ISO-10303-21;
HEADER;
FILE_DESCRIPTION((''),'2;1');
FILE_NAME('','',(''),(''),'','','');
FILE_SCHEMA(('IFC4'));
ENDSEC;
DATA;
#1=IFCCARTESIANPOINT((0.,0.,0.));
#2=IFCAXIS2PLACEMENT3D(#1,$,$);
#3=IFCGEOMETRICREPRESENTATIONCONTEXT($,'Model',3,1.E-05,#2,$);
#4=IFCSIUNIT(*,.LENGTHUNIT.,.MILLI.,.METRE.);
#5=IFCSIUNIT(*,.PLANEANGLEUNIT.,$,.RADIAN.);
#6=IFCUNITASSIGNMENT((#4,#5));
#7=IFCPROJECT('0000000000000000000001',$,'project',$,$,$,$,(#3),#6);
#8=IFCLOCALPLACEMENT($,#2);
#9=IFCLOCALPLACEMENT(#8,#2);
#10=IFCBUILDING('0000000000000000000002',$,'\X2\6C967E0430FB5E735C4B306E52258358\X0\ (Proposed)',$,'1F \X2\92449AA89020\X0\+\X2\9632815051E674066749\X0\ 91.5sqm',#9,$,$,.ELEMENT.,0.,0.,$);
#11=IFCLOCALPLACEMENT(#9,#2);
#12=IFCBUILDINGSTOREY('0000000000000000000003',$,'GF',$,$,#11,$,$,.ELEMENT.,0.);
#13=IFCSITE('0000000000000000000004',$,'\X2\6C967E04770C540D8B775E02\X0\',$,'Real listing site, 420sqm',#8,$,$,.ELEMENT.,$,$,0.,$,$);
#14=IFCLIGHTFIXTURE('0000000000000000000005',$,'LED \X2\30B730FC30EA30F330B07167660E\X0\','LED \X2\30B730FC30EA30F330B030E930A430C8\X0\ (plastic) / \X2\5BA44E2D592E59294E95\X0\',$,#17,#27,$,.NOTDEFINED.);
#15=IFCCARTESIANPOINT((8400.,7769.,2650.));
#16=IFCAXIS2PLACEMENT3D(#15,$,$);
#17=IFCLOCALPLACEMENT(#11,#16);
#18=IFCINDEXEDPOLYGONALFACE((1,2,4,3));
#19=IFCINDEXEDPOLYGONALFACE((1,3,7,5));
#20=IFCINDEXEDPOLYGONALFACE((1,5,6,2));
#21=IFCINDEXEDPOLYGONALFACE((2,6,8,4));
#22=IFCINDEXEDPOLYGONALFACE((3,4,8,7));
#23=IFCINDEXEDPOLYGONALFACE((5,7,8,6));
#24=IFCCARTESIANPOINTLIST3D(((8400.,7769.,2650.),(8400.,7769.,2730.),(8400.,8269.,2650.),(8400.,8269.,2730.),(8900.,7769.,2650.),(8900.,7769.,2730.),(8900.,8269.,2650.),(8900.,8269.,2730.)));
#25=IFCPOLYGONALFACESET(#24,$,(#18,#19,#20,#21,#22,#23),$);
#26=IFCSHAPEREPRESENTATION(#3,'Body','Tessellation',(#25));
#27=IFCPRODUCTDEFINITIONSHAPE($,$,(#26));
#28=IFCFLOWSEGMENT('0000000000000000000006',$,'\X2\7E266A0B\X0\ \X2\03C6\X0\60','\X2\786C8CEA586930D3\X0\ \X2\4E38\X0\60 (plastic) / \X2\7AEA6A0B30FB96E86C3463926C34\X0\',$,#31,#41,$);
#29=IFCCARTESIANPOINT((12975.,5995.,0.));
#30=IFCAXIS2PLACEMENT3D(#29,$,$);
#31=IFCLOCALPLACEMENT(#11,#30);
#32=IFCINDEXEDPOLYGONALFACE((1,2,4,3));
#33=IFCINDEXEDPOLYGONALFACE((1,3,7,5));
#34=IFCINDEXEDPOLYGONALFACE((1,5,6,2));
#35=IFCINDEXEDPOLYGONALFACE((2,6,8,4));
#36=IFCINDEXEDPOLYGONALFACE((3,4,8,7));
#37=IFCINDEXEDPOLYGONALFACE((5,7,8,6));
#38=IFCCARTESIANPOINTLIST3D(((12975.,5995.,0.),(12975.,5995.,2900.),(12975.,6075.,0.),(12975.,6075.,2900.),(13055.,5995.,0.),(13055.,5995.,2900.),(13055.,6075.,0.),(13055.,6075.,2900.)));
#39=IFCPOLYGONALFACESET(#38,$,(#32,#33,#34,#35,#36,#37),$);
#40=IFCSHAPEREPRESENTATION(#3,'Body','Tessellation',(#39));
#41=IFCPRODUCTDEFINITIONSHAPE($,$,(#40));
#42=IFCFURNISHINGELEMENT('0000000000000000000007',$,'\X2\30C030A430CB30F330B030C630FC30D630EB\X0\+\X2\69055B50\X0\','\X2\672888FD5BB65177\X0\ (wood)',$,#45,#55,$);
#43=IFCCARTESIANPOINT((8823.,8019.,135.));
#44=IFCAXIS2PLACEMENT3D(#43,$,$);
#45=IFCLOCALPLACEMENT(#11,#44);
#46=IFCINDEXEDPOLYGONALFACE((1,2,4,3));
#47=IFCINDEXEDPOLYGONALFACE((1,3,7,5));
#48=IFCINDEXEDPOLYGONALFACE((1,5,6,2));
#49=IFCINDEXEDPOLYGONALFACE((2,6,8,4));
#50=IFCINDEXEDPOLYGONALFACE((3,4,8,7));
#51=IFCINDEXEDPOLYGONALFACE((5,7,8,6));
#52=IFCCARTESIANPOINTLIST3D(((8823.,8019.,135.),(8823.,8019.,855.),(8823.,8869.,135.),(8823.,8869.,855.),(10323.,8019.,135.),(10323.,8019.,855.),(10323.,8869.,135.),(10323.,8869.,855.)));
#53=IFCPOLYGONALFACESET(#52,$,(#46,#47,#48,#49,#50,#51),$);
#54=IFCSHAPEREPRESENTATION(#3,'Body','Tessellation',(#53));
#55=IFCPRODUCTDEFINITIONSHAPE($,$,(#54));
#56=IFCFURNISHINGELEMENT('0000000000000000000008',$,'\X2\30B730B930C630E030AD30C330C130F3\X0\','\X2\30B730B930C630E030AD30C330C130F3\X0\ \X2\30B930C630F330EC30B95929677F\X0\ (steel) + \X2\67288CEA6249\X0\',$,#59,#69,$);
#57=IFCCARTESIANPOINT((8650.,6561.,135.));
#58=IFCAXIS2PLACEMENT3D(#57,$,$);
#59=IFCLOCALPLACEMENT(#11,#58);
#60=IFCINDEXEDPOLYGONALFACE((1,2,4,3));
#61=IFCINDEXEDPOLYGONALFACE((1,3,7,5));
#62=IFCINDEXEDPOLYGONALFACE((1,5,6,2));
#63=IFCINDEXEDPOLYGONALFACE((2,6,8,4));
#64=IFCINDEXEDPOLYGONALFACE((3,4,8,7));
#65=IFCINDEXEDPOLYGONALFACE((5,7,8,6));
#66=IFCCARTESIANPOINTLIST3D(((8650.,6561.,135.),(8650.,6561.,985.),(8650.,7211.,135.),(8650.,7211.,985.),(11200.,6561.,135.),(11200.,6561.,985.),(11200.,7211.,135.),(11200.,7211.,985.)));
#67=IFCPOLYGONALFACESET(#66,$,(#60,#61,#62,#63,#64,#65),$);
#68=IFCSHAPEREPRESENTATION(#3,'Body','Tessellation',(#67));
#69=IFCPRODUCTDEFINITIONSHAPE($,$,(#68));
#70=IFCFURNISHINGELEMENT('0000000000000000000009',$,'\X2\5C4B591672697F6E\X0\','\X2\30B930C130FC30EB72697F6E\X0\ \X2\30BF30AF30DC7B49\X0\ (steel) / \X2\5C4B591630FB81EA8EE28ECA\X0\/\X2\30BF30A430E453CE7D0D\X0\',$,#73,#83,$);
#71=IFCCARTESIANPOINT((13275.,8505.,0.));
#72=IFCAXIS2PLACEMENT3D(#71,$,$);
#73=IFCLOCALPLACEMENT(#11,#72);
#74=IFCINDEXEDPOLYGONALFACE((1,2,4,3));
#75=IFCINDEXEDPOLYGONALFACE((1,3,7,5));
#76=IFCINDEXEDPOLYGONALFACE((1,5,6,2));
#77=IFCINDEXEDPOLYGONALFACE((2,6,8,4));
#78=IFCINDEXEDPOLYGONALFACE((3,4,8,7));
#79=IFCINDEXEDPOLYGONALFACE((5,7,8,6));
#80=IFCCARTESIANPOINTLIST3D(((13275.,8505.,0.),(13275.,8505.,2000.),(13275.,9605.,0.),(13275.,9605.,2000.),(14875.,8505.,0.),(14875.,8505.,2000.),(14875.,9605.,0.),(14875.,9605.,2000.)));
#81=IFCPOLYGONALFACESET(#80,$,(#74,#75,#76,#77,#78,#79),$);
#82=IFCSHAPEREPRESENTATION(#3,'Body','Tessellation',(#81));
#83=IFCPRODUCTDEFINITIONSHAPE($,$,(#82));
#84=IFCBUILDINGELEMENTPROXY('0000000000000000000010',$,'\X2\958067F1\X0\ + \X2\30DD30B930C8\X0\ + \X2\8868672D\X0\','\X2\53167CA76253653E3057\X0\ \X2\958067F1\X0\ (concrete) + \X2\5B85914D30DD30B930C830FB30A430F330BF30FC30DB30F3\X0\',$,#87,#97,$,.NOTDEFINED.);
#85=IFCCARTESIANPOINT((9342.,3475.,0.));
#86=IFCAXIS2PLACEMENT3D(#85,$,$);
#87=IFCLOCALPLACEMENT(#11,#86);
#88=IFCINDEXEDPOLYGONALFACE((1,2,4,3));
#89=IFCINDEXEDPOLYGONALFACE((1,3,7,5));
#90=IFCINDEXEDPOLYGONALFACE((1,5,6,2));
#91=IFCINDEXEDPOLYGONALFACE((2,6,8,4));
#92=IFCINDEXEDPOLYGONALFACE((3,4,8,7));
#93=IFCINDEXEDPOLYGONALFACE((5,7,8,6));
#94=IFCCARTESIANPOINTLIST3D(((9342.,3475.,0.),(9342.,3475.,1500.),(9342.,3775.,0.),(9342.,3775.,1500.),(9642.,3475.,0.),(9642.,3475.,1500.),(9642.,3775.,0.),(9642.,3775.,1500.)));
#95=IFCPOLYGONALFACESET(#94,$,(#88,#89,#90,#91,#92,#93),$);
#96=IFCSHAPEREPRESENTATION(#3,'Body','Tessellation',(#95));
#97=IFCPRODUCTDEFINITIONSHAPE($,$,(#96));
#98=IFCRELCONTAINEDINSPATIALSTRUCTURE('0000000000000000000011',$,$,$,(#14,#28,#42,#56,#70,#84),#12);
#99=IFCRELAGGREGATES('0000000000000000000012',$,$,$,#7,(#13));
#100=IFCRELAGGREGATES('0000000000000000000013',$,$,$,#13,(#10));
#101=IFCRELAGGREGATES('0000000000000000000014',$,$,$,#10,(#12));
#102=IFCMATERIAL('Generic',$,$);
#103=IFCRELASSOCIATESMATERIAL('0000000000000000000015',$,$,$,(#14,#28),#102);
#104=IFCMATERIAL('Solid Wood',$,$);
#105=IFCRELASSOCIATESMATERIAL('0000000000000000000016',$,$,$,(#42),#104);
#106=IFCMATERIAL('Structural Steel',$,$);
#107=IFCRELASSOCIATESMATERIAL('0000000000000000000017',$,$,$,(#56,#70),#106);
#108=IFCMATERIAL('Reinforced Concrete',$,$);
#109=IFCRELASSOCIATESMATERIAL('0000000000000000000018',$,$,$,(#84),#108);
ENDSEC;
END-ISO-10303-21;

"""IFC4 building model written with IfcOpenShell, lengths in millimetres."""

from ifc_helpers import new_model, si_unit, frame, frame_2d, origin, place, context, project, spatial, rectangle, extrude, material, element, save


model = new_model("IFC4")

# Units and contexts
model_context = context("Model", 3, precision=1e-05, world=origin())
ifc_project = project(units=[si_unit("LENGTHUNIT", "METRE", prefix="MILLI"), si_unit("PLANEANGLEUNIT", "RADIAN")], contexts=[model_context])

# Site, building, storey
site_placement = place(None, origin())
site = spatial("IfcSite", under=ifc_project, at=site_placement, Name="沖縄県名護市", ObjectType="Real listing site, 420sqm", CompositionType="ELEMENT", RefElevation=0.0)
building_placement = place(site_placement, origin())
building = spatial("IfcBuilding", under=site, at=building_placement, Name="沖縄・平屋の別荘 (Proposed)", ObjectType="1F 鉄骨造+防腐処理杉 91.5sqm", CompositionType="ELEMENT", ElevationOfRefHeight=0.0, ElevationOfTerrain=0.0)
storey_placement = place(building_placement, origin())
storey = spatial("IfcBuildingStorey", under=building, at=storey_placement, Name="GF", CompositionType="ELEMENT", Elevation=0.0)

# Shared definitions
ifc_material_1 = material(Name="Solid Wood")

# Shared definitions
ifc_material_2 = material(Name="Structural Steel")

# Shared definitions
ifc_material_3 = material(Name="Reinforced Concrete")

# Shared definitions
ifc_material_4 = material(Name="Generic")

# Light fixture
light_fixture_placement = place(storey_placement, frame((8400.0, 7769.0, 2650.0)))
element("IfcLightFixture", 1, at=light_fixture_placement, inside=storey, material=ifc_material_4, Name="LED シーリング照明", Description="LED シーリングライト (plastic) / 室中央天井", PredefinedType="NOTDEFINED", context=model_context, shape_type="SweptSolid", body=[
    extrude(rectangle(XDim=500.0, YDim=500.0, at=frame_2d((250.0, 250.0))), frame((8400.0, 7769.0, 2650.0)), (0.0, 0.0, 1.0), 80.0),
])

# Flow segment
flow_segment_placement = place(storey_placement, frame((12975.0, 5995.0, 0.0)))
element("IfcFlowSegment", 2, at=flow_segment_placement, inside=storey, material=ifc_material_4, Name="縦樋 φ60", Description="硬質塩ビ 丸60 (plastic) / 竪樋・雨水排水", context=model_context, shape_type="SweptSolid", body=[
    extrude(rectangle(XDim=80.0, YDim=80.0, at=frame_2d((40.0, 40.0))), frame((12975.0, 5995.0, 0.0)), (0.0, 0.0, 1.0), 2900.0),
])

# Furnishing elements
furnishing_1_placement = place(storey_placement, frame((8823.0, 8019.0, 135.0)))
element("IfcFurnishingElement", 3, at=furnishing_1_placement, inside=storey, material=ifc_material_1, Name="ダイニングテーブル+椅子", Description="木製家具 (wood)", context=model_context, shape_type="SweptSolid", body=[
    extrude(rectangle(XDim=1500.0, YDim=850.0, at=frame_2d((750.0, 425.0))), frame((8823.0, 8019.0, 135.0)), (0.0, 0.0, 1.0), 720.0),
])
furnishing_2_placement = place(storey_placement, frame((8650.0, 6561.0, 135.0)))
element("IfcFurnishingElement", 4, at=furnishing_2_placement, inside=storey, material=ifc_material_2, Name="システムキッチン", Description="システムキッチン ステンレス天板 (steel) + 木質扉", context=model_context, shape_type="SweptSolid", body=[
    extrude(rectangle(XDim=2550.0, YDim=650.0, at=frame_2d((1275.0, 325.0))), frame((8650.0, 6561.0, 135.0)), (0.0, 0.0, 1.0), 850.0),
])
furnishing_3_placement = place(storey_placement, frame((13275.0, 8505.0, 0.0)))
element("IfcFurnishingElement", 5, at=furnishing_3_placement, inside=storey, material=ifc_material_2, Name="屋外物置", Description="スチール物置 タクボ等 (steel) / 屋外・自転車/タイヤ収納", context=model_context, shape_type="SweptSolid", body=[
    extrude(rectangle(XDim=1600.0, YDim=1100.0, at=frame_2d((800.0, 550.0))), frame((13275.0, 8505.0, 0.0)), (0.0, 0.0, 1.0), 2000.0),
])

# Building element proxy
proxy_placement = place(storey_placement, frame((9342.0, 3475.0, 0.0)))
element("IfcBuildingElementProxy", 6, at=proxy_placement, inside=storey, material=ifc_material_3, Name="門柱 + ポスト + 表札", Description="化粧打放し 門柱 (concrete) + 宅配ポスト・インターホン", PredefinedType="NOTDEFINED", context=model_context, shape_type="SweptSolid", body=[
    extrude(rectangle(XDim=300.0, YDim=300.0, at=frame_2d((150.0, 150.0))), frame((9342.0, 3475.0, 0.0)), (0.0, 0.0, 1.0), 1500.0),
])

save(model, "model.ifc")
